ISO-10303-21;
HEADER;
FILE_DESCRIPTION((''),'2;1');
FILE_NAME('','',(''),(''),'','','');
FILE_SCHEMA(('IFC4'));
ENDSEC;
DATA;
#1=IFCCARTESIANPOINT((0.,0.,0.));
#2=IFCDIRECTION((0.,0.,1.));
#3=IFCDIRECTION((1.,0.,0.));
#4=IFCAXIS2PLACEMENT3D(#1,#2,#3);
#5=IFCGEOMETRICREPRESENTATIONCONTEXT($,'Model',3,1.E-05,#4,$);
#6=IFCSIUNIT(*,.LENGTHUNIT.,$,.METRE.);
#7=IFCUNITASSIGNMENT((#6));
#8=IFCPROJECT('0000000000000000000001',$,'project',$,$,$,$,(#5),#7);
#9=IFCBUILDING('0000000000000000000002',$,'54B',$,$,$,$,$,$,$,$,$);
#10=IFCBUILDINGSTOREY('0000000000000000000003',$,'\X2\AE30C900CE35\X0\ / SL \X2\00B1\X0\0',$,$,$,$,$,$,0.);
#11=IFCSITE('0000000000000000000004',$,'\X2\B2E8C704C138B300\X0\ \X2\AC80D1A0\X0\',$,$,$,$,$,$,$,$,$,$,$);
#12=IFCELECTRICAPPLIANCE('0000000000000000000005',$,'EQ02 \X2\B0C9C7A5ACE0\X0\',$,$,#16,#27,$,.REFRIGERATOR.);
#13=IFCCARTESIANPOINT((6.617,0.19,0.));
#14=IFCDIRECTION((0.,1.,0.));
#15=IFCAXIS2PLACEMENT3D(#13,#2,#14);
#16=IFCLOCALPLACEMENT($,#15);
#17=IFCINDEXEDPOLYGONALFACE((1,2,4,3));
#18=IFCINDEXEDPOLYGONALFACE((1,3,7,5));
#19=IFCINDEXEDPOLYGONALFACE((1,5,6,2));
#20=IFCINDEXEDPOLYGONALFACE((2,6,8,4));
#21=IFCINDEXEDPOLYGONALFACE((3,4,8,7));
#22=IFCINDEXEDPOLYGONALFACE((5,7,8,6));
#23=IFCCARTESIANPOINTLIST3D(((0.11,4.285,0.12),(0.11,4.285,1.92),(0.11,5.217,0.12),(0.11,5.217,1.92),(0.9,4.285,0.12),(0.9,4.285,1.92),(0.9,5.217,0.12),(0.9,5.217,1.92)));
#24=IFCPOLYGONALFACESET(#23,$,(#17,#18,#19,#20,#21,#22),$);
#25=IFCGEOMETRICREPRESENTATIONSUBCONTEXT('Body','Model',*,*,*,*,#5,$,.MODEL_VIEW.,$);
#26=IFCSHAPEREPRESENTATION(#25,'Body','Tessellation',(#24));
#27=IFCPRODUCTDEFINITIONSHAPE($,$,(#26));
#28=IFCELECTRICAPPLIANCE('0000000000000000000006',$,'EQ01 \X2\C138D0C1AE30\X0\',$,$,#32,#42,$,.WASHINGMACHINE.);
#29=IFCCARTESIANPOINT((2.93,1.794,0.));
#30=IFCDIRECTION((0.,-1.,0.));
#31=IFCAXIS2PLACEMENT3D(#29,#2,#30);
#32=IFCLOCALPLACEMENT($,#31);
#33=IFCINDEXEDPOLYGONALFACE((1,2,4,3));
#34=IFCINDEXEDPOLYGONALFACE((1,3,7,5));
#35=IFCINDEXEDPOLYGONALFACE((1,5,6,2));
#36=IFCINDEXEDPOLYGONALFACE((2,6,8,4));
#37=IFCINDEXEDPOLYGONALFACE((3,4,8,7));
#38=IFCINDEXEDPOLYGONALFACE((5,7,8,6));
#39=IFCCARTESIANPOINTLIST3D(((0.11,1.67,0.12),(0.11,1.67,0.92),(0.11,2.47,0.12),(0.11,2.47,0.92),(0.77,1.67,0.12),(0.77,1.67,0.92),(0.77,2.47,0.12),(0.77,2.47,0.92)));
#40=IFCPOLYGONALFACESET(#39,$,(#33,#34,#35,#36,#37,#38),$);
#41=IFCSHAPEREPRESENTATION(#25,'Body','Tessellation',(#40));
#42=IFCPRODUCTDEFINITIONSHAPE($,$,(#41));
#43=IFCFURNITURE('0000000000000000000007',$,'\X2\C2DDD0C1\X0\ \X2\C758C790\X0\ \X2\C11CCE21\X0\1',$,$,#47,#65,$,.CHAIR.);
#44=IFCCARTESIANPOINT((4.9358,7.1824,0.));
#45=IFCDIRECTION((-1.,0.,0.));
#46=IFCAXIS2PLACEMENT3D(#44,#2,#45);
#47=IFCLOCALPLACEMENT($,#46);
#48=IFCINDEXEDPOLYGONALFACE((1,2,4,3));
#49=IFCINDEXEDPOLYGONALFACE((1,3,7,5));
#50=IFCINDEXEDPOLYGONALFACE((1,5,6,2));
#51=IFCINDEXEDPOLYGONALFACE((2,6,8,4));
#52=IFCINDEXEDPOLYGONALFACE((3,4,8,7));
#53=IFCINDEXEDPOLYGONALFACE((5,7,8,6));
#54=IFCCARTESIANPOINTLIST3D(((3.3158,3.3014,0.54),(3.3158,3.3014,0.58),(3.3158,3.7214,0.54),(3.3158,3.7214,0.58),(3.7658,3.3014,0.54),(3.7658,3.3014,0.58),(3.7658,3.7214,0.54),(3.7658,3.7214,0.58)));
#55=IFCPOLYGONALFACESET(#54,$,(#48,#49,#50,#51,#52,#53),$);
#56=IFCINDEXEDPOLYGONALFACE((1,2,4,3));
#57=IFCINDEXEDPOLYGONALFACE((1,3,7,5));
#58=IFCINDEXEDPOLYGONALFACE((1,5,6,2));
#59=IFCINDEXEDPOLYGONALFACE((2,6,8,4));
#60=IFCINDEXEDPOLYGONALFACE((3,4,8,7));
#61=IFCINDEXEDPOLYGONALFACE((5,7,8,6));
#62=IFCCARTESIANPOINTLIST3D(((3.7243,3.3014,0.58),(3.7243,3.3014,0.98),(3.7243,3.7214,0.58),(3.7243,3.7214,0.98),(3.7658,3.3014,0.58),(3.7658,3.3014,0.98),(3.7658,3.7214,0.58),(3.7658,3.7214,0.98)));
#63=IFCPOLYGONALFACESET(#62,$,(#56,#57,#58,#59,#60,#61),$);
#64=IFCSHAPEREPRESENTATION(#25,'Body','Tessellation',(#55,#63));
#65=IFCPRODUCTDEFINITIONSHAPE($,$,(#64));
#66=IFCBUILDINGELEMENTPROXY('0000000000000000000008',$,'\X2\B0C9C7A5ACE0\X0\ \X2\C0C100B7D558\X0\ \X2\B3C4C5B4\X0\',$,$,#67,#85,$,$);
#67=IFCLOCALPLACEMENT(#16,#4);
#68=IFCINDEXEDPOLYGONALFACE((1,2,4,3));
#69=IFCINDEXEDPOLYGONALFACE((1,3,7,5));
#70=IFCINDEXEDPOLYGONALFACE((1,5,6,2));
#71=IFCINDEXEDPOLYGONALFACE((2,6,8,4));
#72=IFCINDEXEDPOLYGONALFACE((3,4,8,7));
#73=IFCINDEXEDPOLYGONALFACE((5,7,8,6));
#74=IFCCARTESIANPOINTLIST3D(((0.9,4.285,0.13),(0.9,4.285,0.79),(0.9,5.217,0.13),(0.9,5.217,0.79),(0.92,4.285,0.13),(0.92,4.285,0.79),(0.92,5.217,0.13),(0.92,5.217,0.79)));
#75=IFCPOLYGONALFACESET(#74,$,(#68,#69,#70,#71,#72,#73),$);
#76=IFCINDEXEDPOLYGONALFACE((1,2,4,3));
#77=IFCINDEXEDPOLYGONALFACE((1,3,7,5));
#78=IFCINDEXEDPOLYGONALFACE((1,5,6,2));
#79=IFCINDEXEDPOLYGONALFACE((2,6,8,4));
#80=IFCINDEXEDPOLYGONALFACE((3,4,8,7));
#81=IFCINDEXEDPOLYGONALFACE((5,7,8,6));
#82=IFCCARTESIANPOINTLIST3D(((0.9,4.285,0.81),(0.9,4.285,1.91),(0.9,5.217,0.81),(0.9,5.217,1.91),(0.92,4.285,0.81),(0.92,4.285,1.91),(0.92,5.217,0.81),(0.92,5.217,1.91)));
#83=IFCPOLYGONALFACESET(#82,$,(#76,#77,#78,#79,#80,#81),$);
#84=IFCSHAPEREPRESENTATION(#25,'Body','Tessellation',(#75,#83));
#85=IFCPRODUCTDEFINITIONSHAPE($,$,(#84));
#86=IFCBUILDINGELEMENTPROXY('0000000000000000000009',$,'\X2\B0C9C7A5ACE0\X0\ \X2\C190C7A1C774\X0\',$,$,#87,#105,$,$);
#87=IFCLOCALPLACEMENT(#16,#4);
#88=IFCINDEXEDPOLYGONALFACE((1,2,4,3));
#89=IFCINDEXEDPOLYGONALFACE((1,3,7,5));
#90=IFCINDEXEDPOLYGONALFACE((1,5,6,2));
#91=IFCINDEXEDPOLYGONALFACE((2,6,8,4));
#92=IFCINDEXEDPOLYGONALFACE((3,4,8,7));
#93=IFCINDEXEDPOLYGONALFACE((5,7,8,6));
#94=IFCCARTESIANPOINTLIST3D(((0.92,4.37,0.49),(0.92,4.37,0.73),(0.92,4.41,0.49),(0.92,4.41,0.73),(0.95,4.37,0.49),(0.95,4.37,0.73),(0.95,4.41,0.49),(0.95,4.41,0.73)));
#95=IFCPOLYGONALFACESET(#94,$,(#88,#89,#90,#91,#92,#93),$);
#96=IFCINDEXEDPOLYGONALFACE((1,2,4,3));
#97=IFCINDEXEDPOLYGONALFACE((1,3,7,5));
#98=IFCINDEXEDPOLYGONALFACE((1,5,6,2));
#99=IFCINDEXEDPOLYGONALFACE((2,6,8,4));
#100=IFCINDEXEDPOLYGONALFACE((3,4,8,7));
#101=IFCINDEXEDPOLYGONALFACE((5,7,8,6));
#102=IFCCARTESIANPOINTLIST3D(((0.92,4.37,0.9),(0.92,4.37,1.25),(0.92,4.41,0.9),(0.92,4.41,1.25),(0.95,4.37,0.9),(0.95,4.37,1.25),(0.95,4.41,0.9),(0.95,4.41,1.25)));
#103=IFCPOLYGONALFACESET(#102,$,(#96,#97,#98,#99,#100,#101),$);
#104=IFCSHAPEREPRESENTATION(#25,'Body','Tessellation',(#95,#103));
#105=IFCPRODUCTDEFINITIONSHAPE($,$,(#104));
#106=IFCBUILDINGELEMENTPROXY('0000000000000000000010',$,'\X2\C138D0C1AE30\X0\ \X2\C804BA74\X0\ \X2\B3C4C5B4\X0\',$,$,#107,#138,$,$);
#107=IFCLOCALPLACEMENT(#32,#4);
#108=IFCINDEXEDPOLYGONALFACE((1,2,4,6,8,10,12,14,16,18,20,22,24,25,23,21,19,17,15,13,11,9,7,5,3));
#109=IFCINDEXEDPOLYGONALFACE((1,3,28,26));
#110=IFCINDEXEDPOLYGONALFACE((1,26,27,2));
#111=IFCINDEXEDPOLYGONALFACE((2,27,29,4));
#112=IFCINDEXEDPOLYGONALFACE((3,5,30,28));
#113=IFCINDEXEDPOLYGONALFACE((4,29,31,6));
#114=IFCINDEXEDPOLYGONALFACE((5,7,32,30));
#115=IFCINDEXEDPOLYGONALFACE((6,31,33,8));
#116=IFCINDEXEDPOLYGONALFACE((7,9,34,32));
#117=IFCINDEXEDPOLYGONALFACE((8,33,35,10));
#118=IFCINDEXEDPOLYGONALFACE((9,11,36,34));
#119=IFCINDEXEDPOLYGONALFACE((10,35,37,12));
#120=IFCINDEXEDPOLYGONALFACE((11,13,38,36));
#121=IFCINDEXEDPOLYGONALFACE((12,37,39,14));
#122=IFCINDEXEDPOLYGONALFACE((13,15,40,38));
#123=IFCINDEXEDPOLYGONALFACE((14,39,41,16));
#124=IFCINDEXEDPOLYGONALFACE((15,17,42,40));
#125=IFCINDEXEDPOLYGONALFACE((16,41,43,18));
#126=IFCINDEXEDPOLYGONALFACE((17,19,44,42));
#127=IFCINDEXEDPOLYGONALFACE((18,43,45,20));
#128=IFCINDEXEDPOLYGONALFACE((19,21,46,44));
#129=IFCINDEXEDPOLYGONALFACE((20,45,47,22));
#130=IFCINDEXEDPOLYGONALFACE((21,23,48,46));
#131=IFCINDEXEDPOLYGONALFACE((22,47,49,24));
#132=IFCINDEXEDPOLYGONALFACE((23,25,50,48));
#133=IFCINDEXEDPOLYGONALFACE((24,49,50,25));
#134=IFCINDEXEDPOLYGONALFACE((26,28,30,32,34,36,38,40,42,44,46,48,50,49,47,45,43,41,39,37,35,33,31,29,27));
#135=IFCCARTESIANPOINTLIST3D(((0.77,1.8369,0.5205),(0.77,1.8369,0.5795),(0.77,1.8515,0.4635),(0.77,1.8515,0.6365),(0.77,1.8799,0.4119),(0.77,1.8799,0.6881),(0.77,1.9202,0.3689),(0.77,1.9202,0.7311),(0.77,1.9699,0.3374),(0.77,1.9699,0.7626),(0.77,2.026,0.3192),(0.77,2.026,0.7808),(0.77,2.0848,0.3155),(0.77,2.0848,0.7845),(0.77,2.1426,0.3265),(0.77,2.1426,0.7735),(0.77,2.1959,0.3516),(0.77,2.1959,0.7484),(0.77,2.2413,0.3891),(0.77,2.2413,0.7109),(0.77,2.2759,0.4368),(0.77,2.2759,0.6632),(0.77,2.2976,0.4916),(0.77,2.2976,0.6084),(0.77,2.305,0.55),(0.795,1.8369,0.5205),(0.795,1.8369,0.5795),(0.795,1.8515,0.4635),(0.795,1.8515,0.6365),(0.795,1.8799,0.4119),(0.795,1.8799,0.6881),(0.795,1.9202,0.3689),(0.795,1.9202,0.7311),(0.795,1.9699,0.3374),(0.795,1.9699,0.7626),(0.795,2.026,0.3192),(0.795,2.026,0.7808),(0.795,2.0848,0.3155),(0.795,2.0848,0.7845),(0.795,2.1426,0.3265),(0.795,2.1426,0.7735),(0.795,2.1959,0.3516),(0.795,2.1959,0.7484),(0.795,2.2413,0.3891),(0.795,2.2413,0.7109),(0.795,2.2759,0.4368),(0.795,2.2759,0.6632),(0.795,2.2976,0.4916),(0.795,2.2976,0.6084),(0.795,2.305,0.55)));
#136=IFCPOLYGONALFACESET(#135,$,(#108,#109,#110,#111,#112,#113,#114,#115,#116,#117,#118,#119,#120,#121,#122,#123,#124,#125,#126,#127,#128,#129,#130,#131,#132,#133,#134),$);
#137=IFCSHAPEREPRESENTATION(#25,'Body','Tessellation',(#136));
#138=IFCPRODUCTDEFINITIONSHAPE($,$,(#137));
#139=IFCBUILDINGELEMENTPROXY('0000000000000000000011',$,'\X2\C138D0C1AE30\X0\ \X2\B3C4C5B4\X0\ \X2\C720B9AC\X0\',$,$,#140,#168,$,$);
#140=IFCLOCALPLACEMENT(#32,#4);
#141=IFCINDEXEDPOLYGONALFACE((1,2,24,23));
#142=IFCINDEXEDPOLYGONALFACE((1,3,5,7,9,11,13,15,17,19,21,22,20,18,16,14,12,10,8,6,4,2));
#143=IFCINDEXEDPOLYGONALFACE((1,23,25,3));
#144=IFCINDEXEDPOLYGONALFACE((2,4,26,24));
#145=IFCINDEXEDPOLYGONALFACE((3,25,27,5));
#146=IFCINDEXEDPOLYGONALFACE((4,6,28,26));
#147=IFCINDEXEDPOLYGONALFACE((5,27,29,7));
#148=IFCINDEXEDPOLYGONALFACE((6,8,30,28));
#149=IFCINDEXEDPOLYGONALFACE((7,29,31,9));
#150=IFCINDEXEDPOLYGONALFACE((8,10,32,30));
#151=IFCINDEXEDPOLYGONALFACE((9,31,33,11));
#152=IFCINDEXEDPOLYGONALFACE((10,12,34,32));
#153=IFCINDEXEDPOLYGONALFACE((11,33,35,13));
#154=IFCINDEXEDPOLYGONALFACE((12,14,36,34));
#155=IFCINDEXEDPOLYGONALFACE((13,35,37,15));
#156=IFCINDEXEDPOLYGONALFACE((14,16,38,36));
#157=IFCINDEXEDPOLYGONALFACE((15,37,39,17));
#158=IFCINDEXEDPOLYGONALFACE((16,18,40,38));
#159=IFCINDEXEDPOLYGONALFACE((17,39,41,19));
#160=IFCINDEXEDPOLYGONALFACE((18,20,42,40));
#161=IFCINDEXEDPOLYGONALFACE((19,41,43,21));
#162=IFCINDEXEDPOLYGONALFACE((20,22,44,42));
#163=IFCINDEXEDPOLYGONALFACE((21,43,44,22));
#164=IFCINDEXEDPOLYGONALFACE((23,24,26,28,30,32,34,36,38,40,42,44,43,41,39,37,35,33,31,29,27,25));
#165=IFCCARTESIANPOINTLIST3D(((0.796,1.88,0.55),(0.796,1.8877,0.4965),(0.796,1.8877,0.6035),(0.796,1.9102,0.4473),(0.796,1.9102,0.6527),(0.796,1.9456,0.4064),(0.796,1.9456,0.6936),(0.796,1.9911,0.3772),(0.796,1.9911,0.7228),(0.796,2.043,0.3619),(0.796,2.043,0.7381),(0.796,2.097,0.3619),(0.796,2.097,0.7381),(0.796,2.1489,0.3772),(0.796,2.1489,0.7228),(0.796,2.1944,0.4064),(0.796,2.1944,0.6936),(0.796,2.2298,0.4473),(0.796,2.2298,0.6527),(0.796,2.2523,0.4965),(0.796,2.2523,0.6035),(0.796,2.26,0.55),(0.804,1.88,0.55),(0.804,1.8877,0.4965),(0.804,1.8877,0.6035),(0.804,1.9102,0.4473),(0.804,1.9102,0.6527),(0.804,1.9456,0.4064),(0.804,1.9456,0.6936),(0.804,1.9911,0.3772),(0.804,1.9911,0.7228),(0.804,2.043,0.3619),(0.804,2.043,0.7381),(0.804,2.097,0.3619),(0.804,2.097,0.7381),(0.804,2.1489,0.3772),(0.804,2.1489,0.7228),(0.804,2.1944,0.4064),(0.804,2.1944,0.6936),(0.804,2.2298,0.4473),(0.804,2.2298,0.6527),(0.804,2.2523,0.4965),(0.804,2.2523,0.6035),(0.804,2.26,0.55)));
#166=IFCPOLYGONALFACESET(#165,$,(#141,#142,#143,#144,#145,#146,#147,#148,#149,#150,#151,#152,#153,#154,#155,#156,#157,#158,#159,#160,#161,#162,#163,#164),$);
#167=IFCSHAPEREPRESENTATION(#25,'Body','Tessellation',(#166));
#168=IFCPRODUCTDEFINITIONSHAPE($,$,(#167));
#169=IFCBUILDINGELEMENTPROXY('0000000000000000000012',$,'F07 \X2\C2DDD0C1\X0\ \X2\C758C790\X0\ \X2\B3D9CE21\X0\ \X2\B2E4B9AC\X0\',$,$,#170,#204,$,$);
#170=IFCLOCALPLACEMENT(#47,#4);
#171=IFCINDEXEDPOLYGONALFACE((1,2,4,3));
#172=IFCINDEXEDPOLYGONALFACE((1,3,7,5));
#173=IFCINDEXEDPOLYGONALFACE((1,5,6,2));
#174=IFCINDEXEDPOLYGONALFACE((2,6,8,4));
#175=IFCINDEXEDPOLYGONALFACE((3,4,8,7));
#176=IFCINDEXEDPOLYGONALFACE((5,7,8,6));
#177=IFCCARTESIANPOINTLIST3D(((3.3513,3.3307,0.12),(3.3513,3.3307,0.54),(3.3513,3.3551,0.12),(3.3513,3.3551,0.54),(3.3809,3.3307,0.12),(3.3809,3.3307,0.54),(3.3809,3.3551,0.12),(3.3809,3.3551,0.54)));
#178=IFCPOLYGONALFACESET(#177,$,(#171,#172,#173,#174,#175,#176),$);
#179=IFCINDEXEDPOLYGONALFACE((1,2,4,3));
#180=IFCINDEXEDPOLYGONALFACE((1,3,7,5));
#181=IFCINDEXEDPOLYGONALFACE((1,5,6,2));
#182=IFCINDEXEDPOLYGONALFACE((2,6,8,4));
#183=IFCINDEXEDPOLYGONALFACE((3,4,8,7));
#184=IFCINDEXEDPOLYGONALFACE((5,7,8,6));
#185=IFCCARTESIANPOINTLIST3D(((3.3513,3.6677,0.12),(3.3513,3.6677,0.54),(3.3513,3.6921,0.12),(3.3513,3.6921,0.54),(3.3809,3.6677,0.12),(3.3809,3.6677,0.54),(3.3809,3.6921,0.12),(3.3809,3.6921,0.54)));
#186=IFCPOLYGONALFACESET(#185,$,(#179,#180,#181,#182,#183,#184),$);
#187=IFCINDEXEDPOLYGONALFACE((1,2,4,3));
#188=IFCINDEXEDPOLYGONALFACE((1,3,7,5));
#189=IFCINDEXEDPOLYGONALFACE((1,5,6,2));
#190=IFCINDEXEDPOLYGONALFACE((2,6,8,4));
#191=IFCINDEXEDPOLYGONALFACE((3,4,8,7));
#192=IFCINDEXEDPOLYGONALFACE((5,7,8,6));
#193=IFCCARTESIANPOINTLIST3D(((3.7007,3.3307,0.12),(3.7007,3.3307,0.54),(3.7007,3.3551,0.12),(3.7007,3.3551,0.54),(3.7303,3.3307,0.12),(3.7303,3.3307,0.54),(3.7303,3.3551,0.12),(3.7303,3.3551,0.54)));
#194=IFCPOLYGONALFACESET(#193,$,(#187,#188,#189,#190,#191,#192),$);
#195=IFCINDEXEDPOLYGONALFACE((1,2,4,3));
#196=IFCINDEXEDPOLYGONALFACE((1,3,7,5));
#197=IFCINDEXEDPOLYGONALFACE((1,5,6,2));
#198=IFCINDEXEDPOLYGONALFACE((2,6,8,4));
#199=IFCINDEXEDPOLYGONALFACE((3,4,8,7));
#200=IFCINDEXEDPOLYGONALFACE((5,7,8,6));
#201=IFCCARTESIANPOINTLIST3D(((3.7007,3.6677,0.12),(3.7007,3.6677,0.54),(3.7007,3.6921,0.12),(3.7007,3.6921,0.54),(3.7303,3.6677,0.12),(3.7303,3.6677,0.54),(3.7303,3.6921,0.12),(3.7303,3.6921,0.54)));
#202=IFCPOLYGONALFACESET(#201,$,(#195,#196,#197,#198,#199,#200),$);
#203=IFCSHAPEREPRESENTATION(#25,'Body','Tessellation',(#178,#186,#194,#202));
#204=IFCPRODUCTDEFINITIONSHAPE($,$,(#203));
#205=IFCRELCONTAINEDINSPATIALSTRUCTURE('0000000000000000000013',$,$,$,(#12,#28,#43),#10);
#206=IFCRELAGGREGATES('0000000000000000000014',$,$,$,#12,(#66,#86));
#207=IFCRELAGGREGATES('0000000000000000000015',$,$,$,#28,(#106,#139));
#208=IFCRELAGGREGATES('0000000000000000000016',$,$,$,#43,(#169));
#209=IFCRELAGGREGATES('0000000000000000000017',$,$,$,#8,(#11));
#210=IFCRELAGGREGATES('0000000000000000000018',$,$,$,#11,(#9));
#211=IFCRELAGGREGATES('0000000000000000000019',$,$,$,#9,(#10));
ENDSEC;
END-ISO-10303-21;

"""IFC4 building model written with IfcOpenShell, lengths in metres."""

from ifc_helpers import new_model, si_unit, frame, origin_with_axes, place, context, subcontext, project, spatial, polyline, circle, outline, extrude, element, aggregate, save


model = new_model("IFC4")

# Units and contexts
model_context = context("Model", 3, precision=1e-05, world=origin_with_axes())
body_context = subcontext(model_context, "Body", "Model", "MODEL_VIEW")
ifc_project = project(units=[si_unit("LENGTHUNIT", "METRE")], contexts=[model_context])

# Site, building, storey
site = spatial("IfcSite", under=ifc_project, Name="단위세대 검토")
building = spatial("IfcBuilding", under=site, Name="54B")
storey = spatial("IfcBuildingStorey", under=building, Name="기준층 / SL ±0", Elevation=0.0)

# Electric appliances
electric_appliance_1_placement = place(None, frame((6.617, 0.19, 0.0), z_axis=(0.0, 0.0, 1.0), x_axis=(0.0, 1.0, 0.0)))
electric_appliance_1 = element("IfcElectricAppliance", 1, at=electric_appliance_1_placement, inside=storey, Name="EQ02 냉장고", PredefinedType="REFRIGERATOR", context=body_context, shape_type="SweptSolid", body=[
    extrude(outline(polyline([(0.9, 4.285), (0.9, 5.217), (0.11, 5.217), (0.11, 4.285), (0.9, 4.285)])), frame((0.0, 0.0, 0.12)), (0.0, 0.0, 1.0), 1.8),
])
electric_appliance_2_placement = place(None, frame((2.93, 1.794, 0.0), z_axis=(0.0, 0.0, 1.0), x_axis=(0.0, -1.0, 0.0)))
electric_appliance_2 = element("IfcElectricAppliance", 2, at=electric_appliance_2_placement, inside=storey, Name="EQ01 세탁기", PredefinedType="WASHINGMACHINE", context=body_context, shape_type="SweptSolid", body=[
    extrude(outline(polyline([(0.77, 1.67), (0.77, 2.47), (0.11, 2.47), (0.11, 1.67), (0.77, 1.67)])), frame((0.0, 0.0, 0.12)), (0.0, 0.0, 1.0), 0.8),
])

# Furniture
furniture_1_placement = place(None, frame((4.9358, 7.1824, 0.0), z_axis=(0.0, 0.0, 1.0), x_axis=(-1.0, 0.0, 0.0)))
furniture_1 = element("IfcFurniture", 3, at=furniture_1_placement, inside=storey, Name="식탁 의자 서측1", PredefinedType="CHAIR", context=body_context, shape_type="SweptSolid", body=[
    extrude(outline(polyline([(3.7658, 3.3014), (3.7658, 3.7214), (3.3158, 3.7214), (3.3158, 3.3014), (3.7658, 3.3014)])), frame((0.0, 0.0, 0.54)), (0.0, 0.0, 1.0), 0.04),
    extrude(outline(polyline([(3.7658, 3.3014), (3.7658, 3.7214), (3.7243, 3.7214), (3.7243, 3.3014), (3.7658, 3.3014)])), frame((0.0, 0.0, 0.58)), (0.0, 0.0, 1.0), 0.4),
])

# Building element proxies
proxy_1_placement = place(electric_appliance_1_placement, origin_with_axes())
proxy_1 = element("IfcBuildingElementProxy", 4, at=proxy_1_placement, Name="냉장고 상·하 도어", context=body_context, shape_type="SweptSolid", body=[
    extrude(outline(polyline([(0.92, 4.285), (0.92, 5.217), (0.9, 5.217), (0.9, 4.285), (0.92, 4.285)])), frame((0.0, 0.0, 0.13)), (0.0, 0.0, 1.0), 0.66),
    extrude(outline(polyline([(0.92, 4.285), (0.92, 5.217), (0.9, 5.217), (0.9, 4.285), (0.92, 4.285)])), frame((0.0, 0.0, 0.81)), (0.0, 0.0, 1.0), 1.1),
])
proxy_2_placement = place(electric_appliance_1_placement, origin_with_axes())
proxy_2 = element("IfcBuildingElementProxy", 5, at=proxy_2_placement, Name="냉장고 손잡이", context=body_context, shape_type="SweptSolid", body=[
    extrude(outline(polyline([(0.95, 4.37), (0.95, 4.41), (0.92, 4.41), (0.92, 4.37), (0.95, 4.37)])), frame((0.0, 0.0, 0.49)), (0.0, 0.0, 1.0), 0.24),
    extrude(outline(polyline([(0.95, 4.37), (0.95, 4.41), (0.92, 4.41), (0.92, 4.37), (0.95, 4.37)])), frame((0.0, 0.0, 0.9)), (0.0, 0.0, 1.0), 0.35),
])
aggregate(electric_appliance_1, [proxy_1, proxy_2])
proxy_3_placement = place(electric_appliance_2_placement, origin_with_axes())
proxy_3 = element("IfcBuildingElementProxy", 6, at=proxy_3_placement, Name="세탁기 전면 도어", context=body_context, shape_type="SweptSolid", body=[
    extrude(circle(Radius=0.235), frame((0.77, 2.07, 0.55), z_axis=(1.0, 0.0, 0.0), x_axis=(0.0, 1.0, 0.0)), (0.0, 0.0, 1.0), 0.025),
])
proxy_4_placement = place(electric_appliance_2_placement, origin_with_axes())
proxy_4 = element("IfcBuildingElementProxy", 7, at=proxy_4_placement, Name="세탁기 도어 유리", context=body_context, shape_type="SweptSolid", body=[
    extrude(circle(Radius=0.19), frame((0.796, 2.07, 0.55), z_axis=(1.0, 0.0, 0.0), x_axis=(0.0, 1.0, 0.0)), (0.0, 0.0, 1.0), 0.008),
])
aggregate(electric_appliance_2, [proxy_3, proxy_4])
proxy_5_placement = place(furniture_1_placement, origin_with_axes())
proxy_5 = element("IfcBuildingElementProxy", 8, at=proxy_5_placement, Name="F07 식탁 의자 동측 다리", context=body_context, shape_type="SweptSolid", body=[
    extrude(outline(polyline([(3.3809, 3.3307), (3.3809, 3.3551), (3.3513, 3.3551), (3.3513, 3.3307), (3.3809, 3.3307)])), frame((0.0, 0.0, 0.12)), (0.0, 0.0, 1.0), 0.42),
    extrude(outline(polyline([(3.3809, 3.6677), (3.3809, 3.6921), (3.3513, 3.6921), (3.3513, 3.6677), (3.3809, 3.6677)])), frame((0.0, 0.0, 0.12)), (0.0, 0.0, 1.0), 0.42),
    extrude(outline(polyline([(3.7303, 3.3307), (3.7303, 3.3551), (3.7007, 3.3551), (3.7007, 3.3307), (3.7303, 3.3307)])), frame((0.0, 0.0, 0.12)), (0.0, 0.0, 1.0), 0.42),
    extrude(outline(polyline([(3.7303, 3.6677), (3.7303, 3.6921), (3.7007, 3.6921), (3.7007, 3.6677), (3.7303, 3.6677)])), frame((0.0, 0.0, 0.12)), (0.0, 0.0, 1.0), 0.42),
])
aggregate(furniture_1, [proxy_5])

save(model, "model.ifc")
